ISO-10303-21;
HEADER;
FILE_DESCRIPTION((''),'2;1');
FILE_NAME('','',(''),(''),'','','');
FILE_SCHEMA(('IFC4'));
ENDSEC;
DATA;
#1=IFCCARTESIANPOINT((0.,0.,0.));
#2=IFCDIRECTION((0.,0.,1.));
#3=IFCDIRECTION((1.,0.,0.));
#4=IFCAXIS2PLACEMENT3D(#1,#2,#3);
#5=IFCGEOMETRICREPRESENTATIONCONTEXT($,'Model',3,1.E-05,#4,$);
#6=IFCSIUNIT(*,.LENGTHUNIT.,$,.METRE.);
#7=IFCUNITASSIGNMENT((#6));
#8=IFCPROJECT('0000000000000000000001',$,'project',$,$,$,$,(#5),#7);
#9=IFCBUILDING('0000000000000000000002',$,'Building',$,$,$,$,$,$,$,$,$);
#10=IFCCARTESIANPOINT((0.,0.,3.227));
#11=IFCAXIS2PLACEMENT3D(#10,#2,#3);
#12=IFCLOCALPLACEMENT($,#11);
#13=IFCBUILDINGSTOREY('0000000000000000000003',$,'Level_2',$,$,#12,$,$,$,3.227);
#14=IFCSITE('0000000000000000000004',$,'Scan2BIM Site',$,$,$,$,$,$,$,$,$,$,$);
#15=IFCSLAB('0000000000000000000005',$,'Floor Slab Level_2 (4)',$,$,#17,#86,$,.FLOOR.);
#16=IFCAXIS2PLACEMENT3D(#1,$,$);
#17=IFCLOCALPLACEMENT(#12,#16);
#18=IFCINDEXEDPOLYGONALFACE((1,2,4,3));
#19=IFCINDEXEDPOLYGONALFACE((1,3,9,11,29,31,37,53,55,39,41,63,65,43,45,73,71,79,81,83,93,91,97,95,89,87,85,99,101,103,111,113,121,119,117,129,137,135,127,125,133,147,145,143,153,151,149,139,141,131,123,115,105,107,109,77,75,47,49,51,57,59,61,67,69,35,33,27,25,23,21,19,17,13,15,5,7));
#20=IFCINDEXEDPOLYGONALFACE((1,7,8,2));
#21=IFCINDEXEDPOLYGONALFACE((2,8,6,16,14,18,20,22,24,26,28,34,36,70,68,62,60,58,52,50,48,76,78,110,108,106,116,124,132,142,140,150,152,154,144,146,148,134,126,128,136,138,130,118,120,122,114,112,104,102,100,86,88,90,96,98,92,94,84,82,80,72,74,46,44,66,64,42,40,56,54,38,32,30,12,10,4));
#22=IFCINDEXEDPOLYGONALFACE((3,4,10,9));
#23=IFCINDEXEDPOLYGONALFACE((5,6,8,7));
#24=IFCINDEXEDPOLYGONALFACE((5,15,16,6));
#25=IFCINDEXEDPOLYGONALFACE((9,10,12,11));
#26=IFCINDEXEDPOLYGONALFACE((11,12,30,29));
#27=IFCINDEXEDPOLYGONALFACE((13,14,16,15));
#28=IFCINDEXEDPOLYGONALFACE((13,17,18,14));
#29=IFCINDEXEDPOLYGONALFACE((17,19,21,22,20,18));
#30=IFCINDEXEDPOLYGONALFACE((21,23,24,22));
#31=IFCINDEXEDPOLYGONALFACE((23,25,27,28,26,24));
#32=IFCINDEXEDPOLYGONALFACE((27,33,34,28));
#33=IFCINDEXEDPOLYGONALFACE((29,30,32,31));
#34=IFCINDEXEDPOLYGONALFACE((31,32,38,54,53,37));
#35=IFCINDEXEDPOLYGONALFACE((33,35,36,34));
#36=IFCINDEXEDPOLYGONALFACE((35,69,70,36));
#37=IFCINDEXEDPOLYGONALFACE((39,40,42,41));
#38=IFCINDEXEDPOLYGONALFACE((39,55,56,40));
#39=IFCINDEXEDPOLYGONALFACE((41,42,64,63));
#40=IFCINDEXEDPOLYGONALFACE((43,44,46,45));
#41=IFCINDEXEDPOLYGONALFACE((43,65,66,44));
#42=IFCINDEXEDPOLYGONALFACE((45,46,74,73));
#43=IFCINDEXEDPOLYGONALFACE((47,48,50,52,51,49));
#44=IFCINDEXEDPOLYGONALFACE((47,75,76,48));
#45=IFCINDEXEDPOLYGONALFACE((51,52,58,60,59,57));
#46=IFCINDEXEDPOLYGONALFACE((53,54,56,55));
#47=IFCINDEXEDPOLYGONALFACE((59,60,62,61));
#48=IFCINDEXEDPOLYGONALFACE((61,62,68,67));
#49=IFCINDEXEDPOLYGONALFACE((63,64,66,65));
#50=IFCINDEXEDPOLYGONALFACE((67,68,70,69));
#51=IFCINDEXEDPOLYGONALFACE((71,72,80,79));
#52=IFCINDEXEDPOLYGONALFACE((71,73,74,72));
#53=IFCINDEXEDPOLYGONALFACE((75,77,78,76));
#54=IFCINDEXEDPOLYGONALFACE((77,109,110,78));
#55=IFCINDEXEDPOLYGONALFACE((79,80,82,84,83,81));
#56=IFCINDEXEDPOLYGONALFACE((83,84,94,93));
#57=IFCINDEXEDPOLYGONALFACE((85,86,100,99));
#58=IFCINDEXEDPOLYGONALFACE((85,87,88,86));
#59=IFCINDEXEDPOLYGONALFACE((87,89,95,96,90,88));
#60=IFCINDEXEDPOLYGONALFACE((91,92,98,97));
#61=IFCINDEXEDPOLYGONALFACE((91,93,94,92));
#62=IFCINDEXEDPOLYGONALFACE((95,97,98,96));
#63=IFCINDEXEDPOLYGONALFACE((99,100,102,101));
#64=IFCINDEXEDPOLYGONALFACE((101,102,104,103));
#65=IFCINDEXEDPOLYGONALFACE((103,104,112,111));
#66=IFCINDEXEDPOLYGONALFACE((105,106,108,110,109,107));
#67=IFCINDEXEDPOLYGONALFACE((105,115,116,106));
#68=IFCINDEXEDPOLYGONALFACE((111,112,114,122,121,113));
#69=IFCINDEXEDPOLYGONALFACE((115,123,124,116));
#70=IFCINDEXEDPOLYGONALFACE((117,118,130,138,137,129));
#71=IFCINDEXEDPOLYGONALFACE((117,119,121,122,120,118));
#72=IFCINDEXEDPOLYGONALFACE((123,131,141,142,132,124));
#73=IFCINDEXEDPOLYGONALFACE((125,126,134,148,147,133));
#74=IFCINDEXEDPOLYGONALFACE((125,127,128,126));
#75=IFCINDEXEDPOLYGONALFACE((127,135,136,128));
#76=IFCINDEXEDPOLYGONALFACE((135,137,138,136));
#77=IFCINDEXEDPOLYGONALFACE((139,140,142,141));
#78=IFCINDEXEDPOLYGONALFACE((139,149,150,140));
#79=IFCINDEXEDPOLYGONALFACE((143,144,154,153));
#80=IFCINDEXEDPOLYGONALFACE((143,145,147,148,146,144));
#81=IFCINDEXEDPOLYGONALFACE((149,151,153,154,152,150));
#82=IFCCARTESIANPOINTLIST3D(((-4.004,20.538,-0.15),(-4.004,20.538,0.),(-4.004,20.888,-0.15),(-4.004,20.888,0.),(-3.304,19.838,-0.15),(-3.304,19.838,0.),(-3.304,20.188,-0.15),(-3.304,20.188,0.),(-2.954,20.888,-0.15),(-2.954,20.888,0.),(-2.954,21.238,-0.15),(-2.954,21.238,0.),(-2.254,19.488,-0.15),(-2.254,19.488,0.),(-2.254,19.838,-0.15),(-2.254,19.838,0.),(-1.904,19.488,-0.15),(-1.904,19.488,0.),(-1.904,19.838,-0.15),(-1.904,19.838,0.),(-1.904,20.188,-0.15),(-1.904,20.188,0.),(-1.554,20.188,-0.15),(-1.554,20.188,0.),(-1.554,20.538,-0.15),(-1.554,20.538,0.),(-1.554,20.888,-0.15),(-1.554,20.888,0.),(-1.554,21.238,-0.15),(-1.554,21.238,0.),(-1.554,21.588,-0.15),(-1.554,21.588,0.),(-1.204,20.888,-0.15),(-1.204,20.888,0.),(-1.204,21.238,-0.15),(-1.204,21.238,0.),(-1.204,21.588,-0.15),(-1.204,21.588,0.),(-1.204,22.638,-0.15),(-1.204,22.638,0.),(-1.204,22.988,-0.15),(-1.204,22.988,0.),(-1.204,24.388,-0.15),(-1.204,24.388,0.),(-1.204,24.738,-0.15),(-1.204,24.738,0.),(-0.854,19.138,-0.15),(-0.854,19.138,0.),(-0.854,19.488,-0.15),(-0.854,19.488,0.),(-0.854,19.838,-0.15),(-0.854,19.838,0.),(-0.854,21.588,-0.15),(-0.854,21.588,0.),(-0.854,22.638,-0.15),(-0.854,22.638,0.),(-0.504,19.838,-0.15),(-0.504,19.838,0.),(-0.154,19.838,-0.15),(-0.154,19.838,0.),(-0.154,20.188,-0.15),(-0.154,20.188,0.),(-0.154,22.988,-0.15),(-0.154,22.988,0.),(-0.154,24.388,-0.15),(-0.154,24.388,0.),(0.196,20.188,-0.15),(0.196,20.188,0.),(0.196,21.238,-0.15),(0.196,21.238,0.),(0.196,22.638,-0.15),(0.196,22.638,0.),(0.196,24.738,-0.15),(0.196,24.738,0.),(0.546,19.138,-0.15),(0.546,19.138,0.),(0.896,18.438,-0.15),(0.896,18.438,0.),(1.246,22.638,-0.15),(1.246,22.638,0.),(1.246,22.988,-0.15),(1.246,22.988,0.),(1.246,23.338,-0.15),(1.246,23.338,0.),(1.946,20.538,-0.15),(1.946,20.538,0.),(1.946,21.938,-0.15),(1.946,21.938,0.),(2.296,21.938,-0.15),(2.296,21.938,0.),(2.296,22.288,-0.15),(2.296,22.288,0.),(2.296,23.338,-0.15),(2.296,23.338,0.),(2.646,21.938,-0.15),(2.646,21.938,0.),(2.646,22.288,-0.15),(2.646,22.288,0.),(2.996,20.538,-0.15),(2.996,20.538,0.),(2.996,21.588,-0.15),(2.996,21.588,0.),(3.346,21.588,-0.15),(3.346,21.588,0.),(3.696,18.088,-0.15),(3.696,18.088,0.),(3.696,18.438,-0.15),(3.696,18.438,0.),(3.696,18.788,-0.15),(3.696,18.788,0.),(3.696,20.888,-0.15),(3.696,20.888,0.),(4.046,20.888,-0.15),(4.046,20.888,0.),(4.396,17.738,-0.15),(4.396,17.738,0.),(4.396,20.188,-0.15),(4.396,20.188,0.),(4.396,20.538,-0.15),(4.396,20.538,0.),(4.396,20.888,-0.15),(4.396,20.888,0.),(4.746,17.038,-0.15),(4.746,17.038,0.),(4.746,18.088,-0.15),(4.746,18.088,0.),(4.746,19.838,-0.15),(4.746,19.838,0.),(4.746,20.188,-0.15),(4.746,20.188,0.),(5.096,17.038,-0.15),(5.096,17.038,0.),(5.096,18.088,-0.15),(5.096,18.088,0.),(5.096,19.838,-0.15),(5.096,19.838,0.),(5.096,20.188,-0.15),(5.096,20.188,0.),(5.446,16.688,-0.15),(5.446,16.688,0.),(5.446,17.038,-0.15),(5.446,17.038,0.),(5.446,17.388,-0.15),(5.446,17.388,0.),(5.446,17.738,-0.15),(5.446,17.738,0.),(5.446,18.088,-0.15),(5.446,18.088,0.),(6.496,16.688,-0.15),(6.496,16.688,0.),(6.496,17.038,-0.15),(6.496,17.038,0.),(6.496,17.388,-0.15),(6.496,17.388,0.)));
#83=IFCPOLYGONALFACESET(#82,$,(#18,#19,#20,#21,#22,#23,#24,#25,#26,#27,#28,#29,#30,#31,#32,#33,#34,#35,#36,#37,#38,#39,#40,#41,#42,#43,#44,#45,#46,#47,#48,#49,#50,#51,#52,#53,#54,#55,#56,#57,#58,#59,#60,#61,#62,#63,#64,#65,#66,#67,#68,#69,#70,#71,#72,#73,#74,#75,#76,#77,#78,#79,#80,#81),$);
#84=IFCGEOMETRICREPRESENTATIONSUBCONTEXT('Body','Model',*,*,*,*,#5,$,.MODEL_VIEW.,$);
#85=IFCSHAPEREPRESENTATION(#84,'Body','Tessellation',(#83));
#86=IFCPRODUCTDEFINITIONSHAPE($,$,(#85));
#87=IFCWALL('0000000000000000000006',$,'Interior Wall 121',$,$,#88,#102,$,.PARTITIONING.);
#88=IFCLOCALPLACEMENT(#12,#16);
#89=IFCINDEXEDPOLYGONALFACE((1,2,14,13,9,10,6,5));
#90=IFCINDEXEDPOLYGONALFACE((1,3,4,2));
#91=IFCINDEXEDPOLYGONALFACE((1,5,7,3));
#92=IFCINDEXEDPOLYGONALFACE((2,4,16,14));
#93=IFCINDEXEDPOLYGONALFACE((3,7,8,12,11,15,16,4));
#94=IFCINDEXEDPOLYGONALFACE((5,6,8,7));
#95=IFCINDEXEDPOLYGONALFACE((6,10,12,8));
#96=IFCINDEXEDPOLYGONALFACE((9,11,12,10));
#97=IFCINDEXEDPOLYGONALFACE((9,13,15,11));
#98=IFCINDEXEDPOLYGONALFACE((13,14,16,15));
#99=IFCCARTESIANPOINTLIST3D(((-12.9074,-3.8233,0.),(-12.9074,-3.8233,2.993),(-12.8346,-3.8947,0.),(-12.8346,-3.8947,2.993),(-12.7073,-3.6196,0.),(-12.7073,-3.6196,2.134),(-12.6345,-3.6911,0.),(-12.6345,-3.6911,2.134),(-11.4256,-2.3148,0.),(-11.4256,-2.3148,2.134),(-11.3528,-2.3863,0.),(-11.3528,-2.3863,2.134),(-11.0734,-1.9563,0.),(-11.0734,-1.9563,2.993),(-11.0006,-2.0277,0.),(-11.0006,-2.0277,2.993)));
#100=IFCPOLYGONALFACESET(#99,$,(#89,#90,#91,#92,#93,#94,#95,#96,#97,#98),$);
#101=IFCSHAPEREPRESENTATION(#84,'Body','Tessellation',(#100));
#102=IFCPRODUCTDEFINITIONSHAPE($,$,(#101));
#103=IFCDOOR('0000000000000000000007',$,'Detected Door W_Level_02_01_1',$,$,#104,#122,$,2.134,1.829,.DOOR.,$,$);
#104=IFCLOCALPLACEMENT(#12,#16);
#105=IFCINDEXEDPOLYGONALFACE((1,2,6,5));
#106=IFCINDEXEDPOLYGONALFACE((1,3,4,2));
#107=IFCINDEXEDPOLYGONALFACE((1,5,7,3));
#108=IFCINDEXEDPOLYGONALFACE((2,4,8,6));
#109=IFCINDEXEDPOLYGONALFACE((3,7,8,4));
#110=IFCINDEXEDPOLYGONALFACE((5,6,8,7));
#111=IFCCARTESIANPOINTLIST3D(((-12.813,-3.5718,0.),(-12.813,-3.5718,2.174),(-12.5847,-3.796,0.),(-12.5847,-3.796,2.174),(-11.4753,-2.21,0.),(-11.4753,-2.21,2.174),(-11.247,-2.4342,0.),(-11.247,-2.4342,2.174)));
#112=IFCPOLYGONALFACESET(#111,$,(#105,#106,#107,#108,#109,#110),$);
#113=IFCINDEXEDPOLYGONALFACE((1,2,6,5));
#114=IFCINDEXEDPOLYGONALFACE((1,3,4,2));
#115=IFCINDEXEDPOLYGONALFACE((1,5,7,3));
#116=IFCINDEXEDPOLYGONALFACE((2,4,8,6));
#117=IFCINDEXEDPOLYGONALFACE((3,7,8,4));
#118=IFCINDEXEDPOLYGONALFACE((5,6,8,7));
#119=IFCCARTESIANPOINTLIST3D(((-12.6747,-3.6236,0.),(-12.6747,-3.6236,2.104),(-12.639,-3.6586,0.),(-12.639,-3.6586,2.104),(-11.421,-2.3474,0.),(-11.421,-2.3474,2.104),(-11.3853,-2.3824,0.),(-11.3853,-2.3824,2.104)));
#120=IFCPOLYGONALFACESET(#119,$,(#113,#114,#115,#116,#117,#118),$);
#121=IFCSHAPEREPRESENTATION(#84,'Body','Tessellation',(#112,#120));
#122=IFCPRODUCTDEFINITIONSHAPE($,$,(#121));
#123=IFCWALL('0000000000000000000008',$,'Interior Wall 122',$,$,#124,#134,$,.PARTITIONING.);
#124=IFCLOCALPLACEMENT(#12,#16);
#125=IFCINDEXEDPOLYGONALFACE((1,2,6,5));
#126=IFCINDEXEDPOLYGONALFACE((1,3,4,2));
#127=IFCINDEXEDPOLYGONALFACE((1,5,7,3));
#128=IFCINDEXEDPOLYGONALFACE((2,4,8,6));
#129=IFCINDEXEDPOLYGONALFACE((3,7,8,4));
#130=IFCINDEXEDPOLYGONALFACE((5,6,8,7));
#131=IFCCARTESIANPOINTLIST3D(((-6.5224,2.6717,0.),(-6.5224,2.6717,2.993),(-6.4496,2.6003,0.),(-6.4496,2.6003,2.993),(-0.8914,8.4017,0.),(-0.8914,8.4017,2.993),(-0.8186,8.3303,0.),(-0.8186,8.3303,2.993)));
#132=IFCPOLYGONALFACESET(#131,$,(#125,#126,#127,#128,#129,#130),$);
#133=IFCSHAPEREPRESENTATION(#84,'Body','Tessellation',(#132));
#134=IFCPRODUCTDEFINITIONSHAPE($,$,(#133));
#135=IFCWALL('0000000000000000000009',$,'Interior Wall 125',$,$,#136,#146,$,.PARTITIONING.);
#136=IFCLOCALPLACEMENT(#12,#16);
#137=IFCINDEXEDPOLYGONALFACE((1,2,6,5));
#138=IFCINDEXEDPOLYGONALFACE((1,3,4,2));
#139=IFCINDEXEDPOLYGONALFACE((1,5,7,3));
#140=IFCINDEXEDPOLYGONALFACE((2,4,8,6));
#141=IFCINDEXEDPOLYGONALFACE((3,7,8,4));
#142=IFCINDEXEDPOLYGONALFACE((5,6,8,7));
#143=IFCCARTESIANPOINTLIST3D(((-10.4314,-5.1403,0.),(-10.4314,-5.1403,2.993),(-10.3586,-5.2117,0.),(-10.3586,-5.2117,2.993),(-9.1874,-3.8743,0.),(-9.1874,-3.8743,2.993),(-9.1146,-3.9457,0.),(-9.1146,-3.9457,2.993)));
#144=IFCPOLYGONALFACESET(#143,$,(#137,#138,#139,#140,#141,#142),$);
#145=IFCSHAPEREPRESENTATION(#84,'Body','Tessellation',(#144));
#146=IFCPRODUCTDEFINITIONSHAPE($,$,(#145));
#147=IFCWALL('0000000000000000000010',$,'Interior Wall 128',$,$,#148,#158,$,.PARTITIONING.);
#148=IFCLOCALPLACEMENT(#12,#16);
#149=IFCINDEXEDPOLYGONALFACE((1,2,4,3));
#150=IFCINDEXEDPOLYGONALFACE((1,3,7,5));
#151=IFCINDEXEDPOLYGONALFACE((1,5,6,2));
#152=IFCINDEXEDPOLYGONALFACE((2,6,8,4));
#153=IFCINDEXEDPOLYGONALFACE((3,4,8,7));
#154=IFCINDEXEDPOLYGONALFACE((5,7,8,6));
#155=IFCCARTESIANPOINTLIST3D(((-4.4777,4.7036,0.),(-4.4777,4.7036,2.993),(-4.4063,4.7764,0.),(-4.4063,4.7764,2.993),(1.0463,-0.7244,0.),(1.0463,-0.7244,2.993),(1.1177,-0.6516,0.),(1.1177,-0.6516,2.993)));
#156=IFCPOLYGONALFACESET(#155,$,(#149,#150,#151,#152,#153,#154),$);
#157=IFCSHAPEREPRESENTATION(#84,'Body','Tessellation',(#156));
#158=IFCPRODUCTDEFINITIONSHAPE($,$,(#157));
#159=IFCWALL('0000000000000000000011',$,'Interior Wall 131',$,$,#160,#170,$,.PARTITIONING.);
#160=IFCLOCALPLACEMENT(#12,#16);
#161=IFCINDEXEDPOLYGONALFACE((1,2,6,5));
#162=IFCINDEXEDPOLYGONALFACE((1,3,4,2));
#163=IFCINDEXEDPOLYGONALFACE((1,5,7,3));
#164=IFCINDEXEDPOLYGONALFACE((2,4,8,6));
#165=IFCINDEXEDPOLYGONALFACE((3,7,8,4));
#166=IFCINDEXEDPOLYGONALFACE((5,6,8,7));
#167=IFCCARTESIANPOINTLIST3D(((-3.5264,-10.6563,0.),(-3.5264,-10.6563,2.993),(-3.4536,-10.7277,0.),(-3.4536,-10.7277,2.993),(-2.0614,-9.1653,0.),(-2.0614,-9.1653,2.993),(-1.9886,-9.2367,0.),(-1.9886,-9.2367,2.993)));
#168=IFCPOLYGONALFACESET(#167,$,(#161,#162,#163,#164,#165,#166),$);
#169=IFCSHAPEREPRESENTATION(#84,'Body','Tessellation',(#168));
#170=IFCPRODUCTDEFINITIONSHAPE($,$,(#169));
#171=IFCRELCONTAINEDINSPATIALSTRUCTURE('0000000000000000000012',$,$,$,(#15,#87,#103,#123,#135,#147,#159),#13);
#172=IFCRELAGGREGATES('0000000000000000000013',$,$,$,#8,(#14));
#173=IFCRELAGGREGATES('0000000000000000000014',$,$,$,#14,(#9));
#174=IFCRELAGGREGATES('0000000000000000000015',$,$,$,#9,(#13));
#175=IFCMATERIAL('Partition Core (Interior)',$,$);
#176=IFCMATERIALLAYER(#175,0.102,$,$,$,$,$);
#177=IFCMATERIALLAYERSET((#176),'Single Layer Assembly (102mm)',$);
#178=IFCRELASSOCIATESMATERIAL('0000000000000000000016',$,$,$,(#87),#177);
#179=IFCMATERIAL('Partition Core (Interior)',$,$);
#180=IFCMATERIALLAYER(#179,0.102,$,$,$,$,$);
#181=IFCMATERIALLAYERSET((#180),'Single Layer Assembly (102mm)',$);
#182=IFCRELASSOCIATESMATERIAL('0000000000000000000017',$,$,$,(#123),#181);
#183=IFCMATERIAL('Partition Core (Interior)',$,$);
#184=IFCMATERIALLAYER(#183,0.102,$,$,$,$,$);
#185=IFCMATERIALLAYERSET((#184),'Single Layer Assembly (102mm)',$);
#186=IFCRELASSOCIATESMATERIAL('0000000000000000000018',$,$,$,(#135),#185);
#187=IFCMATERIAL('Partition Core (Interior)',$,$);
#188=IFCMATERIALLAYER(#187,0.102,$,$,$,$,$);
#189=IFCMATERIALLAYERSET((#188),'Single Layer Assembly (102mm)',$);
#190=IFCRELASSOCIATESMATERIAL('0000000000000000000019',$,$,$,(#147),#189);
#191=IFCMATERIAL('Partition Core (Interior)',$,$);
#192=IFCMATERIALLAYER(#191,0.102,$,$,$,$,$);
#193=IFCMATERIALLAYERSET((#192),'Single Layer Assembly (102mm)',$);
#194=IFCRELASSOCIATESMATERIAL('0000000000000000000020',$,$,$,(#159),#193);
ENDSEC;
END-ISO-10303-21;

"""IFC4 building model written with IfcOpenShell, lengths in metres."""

from ifc_helpers import new_model, si_unit, frame, origin, origin_with_axes, place, context, subcontext, project, spatial, polyline, rectangle, outline, extrude, material, layer, layer_set, element, fill, save


model = new_model("IFC4")

# Units and contexts
model_context = context("Model", 3, precision=1e-05, world=origin_with_axes())
body_context = subcontext(model_context, "Body", "Model", "MODEL_VIEW")
ifc_project = project(units=[si_unit("LENGTHUNIT", "METRE")], contexts=[model_context])

# Site, building, storey
site = spatial("IfcSite", under=ifc_project, Name="Scan2BIM Site")
building = spatial("IfcBuilding", under=site, Name="Building")
storey_placement = place(None, frame((0.0, 0.0, 3.227), z_axis=(0.0, 0.0, 1.0), x_axis=(1.0, 0.0, 0.0)))
storey = spatial("IfcBuildingStorey", under=building, at=storey_placement, Name="Level_2", Elevation=3.227)

# Slab
slab_1_placement = place(storey_placement, frame((0.0, 0.0, -0.15), z_axis=(0.0, 0.0, 1.0), x_axis=(1.0, 0.0, 0.0)))
element("IfcSlab", 1, at=slab_1_placement, inside=storey, Name="Floor Slab Level_2 (4)", PredefinedType="FLOOR", context=body_context, shape_type="SweptSolid", body=[
    extrude(outline(polyline([(5.446, 16.688), (6.496, 16.688), (6.496, 17.038), (6.496, 17.388), (5.446, 17.388), (5.446, 17.738), (5.446, 18.088), (5.096, 18.088), (4.746, 18.088), (4.746, 19.838), (5.096, 19.838), (5.096, 20.188), (4.746, 20.188), (4.396, 20.188), (4.396, 20.538), (4.396, 20.888), (4.046, 20.888), (3.696, 20.888), (3.346, 21.588), (2.996, 21.588), (2.996, 20.538), (1.946, 20.538), (1.946, 21.938), (2.296, 21.938), (2.646, 21.938), (2.646, 22.288), (2.296, 22.288), (2.296, 23.338), (1.246, 23.338), (1.246, 22.988), (1.246, 22.638), (0.196, 22.638), (0.196, 24.738), (-1.204, 24.738), (-1.204, 24.388), (-0.154, 24.388), (-0.154, 22.988), (-1.204, 22.988), (-1.204, 22.638), (-0.854, 22.638), (-0.854, 21.588), (-1.204, 21.588), (-1.554, 21.588), (-1.554, 21.238), (-2.954, 21.238), (-2.954, 20.888), (-4.004, 20.888), (-4.004, 20.538), (-3.304, 20.188), (-3.304, 19.838), (-2.254, 19.838), (-2.254, 19.488), (-1.904, 19.488), (-1.904, 19.838), (-1.904, 20.188), (-1.554, 20.188), (-1.554, 20.538), (-1.554, 20.888), (-1.204, 20.888), (-1.204, 21.238), (0.196, 21.238), (0.196, 20.188), (-0.154, 20.188), (-0.154, 19.838), (-0.504, 19.838), (-0.854, 19.838), (-0.854, 19.488), (-0.854, 19.138), (0.546, 19.138), (0.896, 18.438), (3.696, 18.788), (3.696, 18.438), (3.696, 18.088), (4.396, 17.738), (4.746, 17.038), (5.096, 17.038), (5.446, 17.038), (5.446, 16.688)])), origin(), (0.0, 0.0, 1.0), 0.15),
])

# Wall, opening, door
ifc_material_1 = material(Name="Partition Core (Interior)")
ifc_layer_1 = layer(ifc_material_1, 0.102)
ifc_layer_set_1 = layer_set([ifc_layer_1], Name="Single Layer Assembly (102mm)")
wall_1_placement = place(storey_placement, frame((-11.954, -2.9255, 0.0), z_axis=(0.0, 0.0, 1.0), x_axis=(0.700774, 0.713383, 0.0)))
wall_1 = element("IfcWall", 2, at=wall_1_placement, inside=storey, material=ifc_layer_set_1, Name="Interior Wall 121", PredefinedType="PARTITIONING", context=body_context, shape_type="SweptSolid", body=[
    extrude(rectangle(XDim=2.6171, YDim=0.102), origin(), (0.0, 0.0, 1.0), 2.993),
])
opening_1_placement = place(None, frame((-12.03, -3.003, 3.227), z_axis=(0.0, 0.0, 1.0), x_axis=(0.700774, 0.713383, 0.0)))
opening_1 = element("IfcOpeningElement", 3, at=opening_1_placement, cuts=wall_1, PredefinedType="OPENING", context=body_context, shape_type="SweptSolid", body=[
    extrude(rectangle(XDim=1.829, YDim=0.202), origin(), (0.0, 0.0, 1.0), 2.134),
])
door_1_placement = place(opening_1_placement, frame((0.0, 0.0, 0.0), z_axis=(0.0, 0.0, 1.0), x_axis=(1.0, 0.0, 0.0)))
door_1 = element("IfcDoor", 4, at=door_1_placement, inside=storey, Name="Detected Door W_Level_02_01_1", OverallHeight=2.134, OverallWidth=1.829, PredefinedType="DOOR", context=body_context, shape_type="SweptSolid", body=[
    extrude(rectangle(XDim=1.909, YDim=0.32), origin(), (0.0, 0.0, 1.0), 2.174),
    extrude(rectangle(XDim=1.789, YDim=0.05), origin(), (0.0, 0.0, 1.0), 2.104),
])
fill(opening_1, door_1)

# Walls
ifc_material_2 = material(Name="Partition Core (Interior)")
ifc_layer_2 = layer(ifc_material_2, 0.102)
ifc_layer_set_2 = layer_set([ifc_layer_2], Name="Single Layer Assembly (102mm)")
wall_2_placement = place(storey_placement, frame((-3.6705, 5.501, 0.0), z_axis=(0.0, 0.0, 1.0), x_axis=(0.700918, 0.713241, 0.0)))
element("IfcWall", 5, at=wall_2_placement, inside=storey, material=ifc_layer_set_2, Name="Interior Wall 122", PredefinedType="PARTITIONING", context=body_context, shape_type="SweptSolid", body=[
    extrude(rectangle(XDim=8.0337, YDim=0.102), origin(), (0.0, 0.0, 1.0), 2.993),
])
ifc_material_3 = material(Name="Partition Core (Interior)")
ifc_layer_3 = layer(ifc_material_3, 0.102)
ifc_layer_set_3 = layer_set([ifc_layer_3], Name="Single Layer Assembly (102mm)")
wall_3_placement = place(storey_placement, frame((-9.773, -4.543, 0.0), z_axis=(0.0, 0.0, 1.0), x_axis=(0.700882, 0.713277, 0.0)))
element("IfcWall", 6, at=wall_3_placement, inside=storey, material=ifc_layer_set_3, Name="Interior Wall 125", PredefinedType="PARTITIONING", context=body_context, shape_type="SweptSolid", body=[
    extrude(rectangle(XDim=1.7749, YDim=0.102), origin(), (0.0, 0.0, 1.0), 2.993),
])
ifc_material_4 = material(Name="Partition Core (Interior)")
ifc_layer_4 = layer(ifc_material_4, 0.102)
ifc_layer_set_4 = layer_set([ifc_layer_4], Name="Single Layer Assembly (102mm)")
wall_4_placement = place(storey_placement, frame((-1.68, 2.026, 0.0), z_axis=(0.0, 0.0, 1.0), x_axis=(-0.713278, 0.700882, 0.0)))
element("IfcWall", 7, at=wall_4_placement, inside=storey, material=ifc_layer_set_4, Name="Interior Wall 128", PredefinedType="PARTITIONING", context=body_context, shape_type="SweptSolid", body=[
    extrude(rectangle(XDim=7.7445, YDim=0.102), origin(), (0.0, 0.0, 1.0), 2.993),
])
ifc_material_5 = material(Name="Partition Core (Interior)")
ifc_layer_5 = layer(ifc_material_5, 0.102)
ifc_layer_set_5 = layer_set([ifc_layer_5], Name="Single Layer Assembly (102mm)")
wall_5_placement = place(storey_placement, frame((-2.7575, -9.9465, 0.0), z_axis=(0.0, 0.0, 1.0), x_axis=(0.70086, 0.713299, 0.0)))
element("IfcWall", 8, at=wall_5_placement, inside=storey, material=ifc_layer_set_5, Name="Interior Wall 131", PredefinedType="PARTITIONING", context=body_context, shape_type="SweptSolid", body=[
    extrude(rectangle(XDim=2.0903, YDim=0.102), origin(), (0.0, 0.0, 1.0), 2.993),
])

save(model, "model.ifc")
